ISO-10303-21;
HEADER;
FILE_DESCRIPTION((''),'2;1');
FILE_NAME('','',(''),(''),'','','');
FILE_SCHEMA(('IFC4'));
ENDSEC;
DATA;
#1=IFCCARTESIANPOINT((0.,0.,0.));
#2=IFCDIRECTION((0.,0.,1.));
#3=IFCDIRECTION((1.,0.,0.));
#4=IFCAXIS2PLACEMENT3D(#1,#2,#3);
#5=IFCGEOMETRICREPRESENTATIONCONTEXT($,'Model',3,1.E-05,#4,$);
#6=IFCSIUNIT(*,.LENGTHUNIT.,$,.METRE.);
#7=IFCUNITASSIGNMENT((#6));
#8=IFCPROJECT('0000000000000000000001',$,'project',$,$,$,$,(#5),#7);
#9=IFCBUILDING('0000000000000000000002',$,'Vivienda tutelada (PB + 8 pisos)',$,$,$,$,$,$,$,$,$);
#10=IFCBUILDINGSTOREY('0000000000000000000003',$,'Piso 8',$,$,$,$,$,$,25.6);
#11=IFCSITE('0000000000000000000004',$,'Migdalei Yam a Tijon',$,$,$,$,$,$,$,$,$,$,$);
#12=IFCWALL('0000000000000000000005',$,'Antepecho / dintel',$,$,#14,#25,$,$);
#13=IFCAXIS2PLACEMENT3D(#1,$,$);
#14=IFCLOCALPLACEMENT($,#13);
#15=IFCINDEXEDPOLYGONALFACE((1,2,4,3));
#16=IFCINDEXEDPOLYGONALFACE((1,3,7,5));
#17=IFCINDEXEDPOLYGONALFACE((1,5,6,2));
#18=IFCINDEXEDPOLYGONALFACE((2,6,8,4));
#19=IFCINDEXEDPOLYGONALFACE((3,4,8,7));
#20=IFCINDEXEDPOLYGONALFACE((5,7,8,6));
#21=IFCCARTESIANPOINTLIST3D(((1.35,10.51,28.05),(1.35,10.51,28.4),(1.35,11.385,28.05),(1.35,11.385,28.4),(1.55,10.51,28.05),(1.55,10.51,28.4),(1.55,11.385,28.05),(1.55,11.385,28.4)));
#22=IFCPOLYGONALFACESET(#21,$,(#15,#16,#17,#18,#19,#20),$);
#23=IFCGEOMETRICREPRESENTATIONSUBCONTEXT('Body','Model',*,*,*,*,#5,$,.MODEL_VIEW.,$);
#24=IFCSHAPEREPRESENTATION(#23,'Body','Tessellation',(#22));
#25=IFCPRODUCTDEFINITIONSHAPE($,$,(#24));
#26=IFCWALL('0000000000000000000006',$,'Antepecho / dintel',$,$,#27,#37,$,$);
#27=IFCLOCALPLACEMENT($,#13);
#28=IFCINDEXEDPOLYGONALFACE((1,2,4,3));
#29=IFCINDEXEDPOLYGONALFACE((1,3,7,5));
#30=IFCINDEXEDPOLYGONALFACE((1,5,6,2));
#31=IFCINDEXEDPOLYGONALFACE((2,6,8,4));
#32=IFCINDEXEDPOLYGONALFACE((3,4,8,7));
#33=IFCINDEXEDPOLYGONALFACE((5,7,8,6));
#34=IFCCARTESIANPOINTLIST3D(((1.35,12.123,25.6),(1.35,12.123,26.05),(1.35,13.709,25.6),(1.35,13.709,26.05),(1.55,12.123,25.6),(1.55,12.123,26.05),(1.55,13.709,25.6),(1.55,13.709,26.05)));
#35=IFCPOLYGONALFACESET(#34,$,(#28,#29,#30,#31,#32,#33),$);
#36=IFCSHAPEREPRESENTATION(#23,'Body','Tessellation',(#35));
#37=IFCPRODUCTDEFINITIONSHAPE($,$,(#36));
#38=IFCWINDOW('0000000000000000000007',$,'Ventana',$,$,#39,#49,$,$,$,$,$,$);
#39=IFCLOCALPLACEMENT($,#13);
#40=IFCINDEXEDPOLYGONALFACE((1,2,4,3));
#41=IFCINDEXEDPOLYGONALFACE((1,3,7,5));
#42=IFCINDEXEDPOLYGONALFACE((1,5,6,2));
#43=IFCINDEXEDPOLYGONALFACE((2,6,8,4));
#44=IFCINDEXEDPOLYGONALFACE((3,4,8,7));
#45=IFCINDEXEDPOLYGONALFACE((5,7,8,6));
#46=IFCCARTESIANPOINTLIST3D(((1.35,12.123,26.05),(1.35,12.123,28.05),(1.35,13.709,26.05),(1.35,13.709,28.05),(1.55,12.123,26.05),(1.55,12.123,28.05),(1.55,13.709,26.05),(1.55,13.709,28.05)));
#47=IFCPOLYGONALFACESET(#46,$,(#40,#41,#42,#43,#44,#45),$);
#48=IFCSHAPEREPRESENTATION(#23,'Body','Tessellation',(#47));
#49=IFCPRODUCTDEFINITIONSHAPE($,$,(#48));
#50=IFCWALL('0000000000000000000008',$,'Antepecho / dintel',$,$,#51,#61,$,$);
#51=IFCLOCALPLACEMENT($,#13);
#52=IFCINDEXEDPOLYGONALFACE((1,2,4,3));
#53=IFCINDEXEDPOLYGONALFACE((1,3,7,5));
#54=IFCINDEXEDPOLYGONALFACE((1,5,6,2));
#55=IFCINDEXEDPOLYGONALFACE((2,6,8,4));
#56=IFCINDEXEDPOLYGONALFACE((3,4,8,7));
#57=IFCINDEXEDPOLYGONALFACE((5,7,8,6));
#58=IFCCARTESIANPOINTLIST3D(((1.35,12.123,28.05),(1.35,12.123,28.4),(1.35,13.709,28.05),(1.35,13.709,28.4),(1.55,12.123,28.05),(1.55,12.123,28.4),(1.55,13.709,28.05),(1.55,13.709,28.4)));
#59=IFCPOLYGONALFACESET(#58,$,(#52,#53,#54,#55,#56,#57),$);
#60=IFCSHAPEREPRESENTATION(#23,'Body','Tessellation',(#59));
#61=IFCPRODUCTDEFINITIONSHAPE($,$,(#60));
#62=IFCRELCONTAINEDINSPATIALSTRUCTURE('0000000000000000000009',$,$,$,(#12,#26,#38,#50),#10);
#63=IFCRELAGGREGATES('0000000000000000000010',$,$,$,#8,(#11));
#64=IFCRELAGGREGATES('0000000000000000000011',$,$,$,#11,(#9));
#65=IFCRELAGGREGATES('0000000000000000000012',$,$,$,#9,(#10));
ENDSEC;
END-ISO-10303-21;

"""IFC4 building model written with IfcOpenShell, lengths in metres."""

from ifc_helpers import new_model, si_unit, frame, origin_with_axes, context, subcontext, project, spatial, line, indexed_curve, outline, extrude, element, save


model = new_model("IFC4")

# Units and contexts
model_context = context("Model", 3, precision=1e-05, world=origin_with_axes())
body_context = subcontext(model_context, "Body", "Model", "MODEL_VIEW")
ifc_project = project(units=[si_unit("LENGTHUNIT", "METRE")], contexts=[model_context])

# Site, building, storey
site = spatial("IfcSite", under=ifc_project, Name="Migdalei Yam a Tijon")
building = spatial("IfcBuilding", under=site, Name="Vivienda tutelada (PB + 8 pisos)")
storey = spatial("IfcBuildingStorey", under=building, Name="Piso 8", Elevation=25.6)

# Walls
element("IfcWall", 1, inside=storey, Name="Antepecho / dintel", context=body_context, shape_type="SweptSolid", body=[
    extrude(outline(indexed_curve([(0.0, 0.0), (0.2, 0.0), (0.2, 0.875), (0.0, 0.875)], segments=[line(1, 2, 3, 4, 1)])), frame((1.35, 10.51, 28.05), z_axis=(0.0, 0.0, 1.0), x_axis=(1.0, 0.0, 0.0)), (0.0, 0.0, 1.0), 0.35),
])
element("IfcWall", 2, inside=storey, Name="Antepecho / dintel", context=body_context, shape_type="SweptSolid", body=[
    extrude(outline(indexed_curve([(0.0, 0.0), (0.2, 0.0), (0.2, 1.586), (0.0, 1.586)], segments=[line(1, 2, 3, 4, 1)])), frame((1.35, 12.123, 25.6), z_axis=(0.0, 0.0, 1.0), x_axis=(1.0, 0.0, 0.0)), (0.0, 0.0, 1.0), 0.45),
])

# Window
element("IfcWindow", 3, inside=storey, Name="Ventana", context=body_context, shape_type="SweptSolid", body=[
    extrude(outline(indexed_curve([(0.0, 0.0), (0.2, 0.0), (0.2, 1.586), (0.0, 1.586)], segments=[line(1, 2, 3, 4, 1)])), frame((1.35, 12.123, 26.05), z_axis=(0.0, 0.0, 1.0), x_axis=(1.0, 0.0, 0.0)), (0.0, 0.0, 1.0), 2.0),
])

# Wall
element("IfcWall", 4, inside=storey, Name="Antepecho / dintel", context=body_context, shape_type="SweptSolid", body=[
    extrude(outline(indexed_curve([(0.0, 0.0), (0.2, 0.0), (0.2, 1.586), (0.0, 1.586)], segments=[line(1, 2, 3, 4, 1)])), frame((1.35, 12.123, 28.05), z_axis=(0.0, 0.0, 1.0), x_axis=(1.0, 0.0, 0.0)), (0.0, 0.0, 1.0), 0.35),
])

save(model, "model.ifc")
